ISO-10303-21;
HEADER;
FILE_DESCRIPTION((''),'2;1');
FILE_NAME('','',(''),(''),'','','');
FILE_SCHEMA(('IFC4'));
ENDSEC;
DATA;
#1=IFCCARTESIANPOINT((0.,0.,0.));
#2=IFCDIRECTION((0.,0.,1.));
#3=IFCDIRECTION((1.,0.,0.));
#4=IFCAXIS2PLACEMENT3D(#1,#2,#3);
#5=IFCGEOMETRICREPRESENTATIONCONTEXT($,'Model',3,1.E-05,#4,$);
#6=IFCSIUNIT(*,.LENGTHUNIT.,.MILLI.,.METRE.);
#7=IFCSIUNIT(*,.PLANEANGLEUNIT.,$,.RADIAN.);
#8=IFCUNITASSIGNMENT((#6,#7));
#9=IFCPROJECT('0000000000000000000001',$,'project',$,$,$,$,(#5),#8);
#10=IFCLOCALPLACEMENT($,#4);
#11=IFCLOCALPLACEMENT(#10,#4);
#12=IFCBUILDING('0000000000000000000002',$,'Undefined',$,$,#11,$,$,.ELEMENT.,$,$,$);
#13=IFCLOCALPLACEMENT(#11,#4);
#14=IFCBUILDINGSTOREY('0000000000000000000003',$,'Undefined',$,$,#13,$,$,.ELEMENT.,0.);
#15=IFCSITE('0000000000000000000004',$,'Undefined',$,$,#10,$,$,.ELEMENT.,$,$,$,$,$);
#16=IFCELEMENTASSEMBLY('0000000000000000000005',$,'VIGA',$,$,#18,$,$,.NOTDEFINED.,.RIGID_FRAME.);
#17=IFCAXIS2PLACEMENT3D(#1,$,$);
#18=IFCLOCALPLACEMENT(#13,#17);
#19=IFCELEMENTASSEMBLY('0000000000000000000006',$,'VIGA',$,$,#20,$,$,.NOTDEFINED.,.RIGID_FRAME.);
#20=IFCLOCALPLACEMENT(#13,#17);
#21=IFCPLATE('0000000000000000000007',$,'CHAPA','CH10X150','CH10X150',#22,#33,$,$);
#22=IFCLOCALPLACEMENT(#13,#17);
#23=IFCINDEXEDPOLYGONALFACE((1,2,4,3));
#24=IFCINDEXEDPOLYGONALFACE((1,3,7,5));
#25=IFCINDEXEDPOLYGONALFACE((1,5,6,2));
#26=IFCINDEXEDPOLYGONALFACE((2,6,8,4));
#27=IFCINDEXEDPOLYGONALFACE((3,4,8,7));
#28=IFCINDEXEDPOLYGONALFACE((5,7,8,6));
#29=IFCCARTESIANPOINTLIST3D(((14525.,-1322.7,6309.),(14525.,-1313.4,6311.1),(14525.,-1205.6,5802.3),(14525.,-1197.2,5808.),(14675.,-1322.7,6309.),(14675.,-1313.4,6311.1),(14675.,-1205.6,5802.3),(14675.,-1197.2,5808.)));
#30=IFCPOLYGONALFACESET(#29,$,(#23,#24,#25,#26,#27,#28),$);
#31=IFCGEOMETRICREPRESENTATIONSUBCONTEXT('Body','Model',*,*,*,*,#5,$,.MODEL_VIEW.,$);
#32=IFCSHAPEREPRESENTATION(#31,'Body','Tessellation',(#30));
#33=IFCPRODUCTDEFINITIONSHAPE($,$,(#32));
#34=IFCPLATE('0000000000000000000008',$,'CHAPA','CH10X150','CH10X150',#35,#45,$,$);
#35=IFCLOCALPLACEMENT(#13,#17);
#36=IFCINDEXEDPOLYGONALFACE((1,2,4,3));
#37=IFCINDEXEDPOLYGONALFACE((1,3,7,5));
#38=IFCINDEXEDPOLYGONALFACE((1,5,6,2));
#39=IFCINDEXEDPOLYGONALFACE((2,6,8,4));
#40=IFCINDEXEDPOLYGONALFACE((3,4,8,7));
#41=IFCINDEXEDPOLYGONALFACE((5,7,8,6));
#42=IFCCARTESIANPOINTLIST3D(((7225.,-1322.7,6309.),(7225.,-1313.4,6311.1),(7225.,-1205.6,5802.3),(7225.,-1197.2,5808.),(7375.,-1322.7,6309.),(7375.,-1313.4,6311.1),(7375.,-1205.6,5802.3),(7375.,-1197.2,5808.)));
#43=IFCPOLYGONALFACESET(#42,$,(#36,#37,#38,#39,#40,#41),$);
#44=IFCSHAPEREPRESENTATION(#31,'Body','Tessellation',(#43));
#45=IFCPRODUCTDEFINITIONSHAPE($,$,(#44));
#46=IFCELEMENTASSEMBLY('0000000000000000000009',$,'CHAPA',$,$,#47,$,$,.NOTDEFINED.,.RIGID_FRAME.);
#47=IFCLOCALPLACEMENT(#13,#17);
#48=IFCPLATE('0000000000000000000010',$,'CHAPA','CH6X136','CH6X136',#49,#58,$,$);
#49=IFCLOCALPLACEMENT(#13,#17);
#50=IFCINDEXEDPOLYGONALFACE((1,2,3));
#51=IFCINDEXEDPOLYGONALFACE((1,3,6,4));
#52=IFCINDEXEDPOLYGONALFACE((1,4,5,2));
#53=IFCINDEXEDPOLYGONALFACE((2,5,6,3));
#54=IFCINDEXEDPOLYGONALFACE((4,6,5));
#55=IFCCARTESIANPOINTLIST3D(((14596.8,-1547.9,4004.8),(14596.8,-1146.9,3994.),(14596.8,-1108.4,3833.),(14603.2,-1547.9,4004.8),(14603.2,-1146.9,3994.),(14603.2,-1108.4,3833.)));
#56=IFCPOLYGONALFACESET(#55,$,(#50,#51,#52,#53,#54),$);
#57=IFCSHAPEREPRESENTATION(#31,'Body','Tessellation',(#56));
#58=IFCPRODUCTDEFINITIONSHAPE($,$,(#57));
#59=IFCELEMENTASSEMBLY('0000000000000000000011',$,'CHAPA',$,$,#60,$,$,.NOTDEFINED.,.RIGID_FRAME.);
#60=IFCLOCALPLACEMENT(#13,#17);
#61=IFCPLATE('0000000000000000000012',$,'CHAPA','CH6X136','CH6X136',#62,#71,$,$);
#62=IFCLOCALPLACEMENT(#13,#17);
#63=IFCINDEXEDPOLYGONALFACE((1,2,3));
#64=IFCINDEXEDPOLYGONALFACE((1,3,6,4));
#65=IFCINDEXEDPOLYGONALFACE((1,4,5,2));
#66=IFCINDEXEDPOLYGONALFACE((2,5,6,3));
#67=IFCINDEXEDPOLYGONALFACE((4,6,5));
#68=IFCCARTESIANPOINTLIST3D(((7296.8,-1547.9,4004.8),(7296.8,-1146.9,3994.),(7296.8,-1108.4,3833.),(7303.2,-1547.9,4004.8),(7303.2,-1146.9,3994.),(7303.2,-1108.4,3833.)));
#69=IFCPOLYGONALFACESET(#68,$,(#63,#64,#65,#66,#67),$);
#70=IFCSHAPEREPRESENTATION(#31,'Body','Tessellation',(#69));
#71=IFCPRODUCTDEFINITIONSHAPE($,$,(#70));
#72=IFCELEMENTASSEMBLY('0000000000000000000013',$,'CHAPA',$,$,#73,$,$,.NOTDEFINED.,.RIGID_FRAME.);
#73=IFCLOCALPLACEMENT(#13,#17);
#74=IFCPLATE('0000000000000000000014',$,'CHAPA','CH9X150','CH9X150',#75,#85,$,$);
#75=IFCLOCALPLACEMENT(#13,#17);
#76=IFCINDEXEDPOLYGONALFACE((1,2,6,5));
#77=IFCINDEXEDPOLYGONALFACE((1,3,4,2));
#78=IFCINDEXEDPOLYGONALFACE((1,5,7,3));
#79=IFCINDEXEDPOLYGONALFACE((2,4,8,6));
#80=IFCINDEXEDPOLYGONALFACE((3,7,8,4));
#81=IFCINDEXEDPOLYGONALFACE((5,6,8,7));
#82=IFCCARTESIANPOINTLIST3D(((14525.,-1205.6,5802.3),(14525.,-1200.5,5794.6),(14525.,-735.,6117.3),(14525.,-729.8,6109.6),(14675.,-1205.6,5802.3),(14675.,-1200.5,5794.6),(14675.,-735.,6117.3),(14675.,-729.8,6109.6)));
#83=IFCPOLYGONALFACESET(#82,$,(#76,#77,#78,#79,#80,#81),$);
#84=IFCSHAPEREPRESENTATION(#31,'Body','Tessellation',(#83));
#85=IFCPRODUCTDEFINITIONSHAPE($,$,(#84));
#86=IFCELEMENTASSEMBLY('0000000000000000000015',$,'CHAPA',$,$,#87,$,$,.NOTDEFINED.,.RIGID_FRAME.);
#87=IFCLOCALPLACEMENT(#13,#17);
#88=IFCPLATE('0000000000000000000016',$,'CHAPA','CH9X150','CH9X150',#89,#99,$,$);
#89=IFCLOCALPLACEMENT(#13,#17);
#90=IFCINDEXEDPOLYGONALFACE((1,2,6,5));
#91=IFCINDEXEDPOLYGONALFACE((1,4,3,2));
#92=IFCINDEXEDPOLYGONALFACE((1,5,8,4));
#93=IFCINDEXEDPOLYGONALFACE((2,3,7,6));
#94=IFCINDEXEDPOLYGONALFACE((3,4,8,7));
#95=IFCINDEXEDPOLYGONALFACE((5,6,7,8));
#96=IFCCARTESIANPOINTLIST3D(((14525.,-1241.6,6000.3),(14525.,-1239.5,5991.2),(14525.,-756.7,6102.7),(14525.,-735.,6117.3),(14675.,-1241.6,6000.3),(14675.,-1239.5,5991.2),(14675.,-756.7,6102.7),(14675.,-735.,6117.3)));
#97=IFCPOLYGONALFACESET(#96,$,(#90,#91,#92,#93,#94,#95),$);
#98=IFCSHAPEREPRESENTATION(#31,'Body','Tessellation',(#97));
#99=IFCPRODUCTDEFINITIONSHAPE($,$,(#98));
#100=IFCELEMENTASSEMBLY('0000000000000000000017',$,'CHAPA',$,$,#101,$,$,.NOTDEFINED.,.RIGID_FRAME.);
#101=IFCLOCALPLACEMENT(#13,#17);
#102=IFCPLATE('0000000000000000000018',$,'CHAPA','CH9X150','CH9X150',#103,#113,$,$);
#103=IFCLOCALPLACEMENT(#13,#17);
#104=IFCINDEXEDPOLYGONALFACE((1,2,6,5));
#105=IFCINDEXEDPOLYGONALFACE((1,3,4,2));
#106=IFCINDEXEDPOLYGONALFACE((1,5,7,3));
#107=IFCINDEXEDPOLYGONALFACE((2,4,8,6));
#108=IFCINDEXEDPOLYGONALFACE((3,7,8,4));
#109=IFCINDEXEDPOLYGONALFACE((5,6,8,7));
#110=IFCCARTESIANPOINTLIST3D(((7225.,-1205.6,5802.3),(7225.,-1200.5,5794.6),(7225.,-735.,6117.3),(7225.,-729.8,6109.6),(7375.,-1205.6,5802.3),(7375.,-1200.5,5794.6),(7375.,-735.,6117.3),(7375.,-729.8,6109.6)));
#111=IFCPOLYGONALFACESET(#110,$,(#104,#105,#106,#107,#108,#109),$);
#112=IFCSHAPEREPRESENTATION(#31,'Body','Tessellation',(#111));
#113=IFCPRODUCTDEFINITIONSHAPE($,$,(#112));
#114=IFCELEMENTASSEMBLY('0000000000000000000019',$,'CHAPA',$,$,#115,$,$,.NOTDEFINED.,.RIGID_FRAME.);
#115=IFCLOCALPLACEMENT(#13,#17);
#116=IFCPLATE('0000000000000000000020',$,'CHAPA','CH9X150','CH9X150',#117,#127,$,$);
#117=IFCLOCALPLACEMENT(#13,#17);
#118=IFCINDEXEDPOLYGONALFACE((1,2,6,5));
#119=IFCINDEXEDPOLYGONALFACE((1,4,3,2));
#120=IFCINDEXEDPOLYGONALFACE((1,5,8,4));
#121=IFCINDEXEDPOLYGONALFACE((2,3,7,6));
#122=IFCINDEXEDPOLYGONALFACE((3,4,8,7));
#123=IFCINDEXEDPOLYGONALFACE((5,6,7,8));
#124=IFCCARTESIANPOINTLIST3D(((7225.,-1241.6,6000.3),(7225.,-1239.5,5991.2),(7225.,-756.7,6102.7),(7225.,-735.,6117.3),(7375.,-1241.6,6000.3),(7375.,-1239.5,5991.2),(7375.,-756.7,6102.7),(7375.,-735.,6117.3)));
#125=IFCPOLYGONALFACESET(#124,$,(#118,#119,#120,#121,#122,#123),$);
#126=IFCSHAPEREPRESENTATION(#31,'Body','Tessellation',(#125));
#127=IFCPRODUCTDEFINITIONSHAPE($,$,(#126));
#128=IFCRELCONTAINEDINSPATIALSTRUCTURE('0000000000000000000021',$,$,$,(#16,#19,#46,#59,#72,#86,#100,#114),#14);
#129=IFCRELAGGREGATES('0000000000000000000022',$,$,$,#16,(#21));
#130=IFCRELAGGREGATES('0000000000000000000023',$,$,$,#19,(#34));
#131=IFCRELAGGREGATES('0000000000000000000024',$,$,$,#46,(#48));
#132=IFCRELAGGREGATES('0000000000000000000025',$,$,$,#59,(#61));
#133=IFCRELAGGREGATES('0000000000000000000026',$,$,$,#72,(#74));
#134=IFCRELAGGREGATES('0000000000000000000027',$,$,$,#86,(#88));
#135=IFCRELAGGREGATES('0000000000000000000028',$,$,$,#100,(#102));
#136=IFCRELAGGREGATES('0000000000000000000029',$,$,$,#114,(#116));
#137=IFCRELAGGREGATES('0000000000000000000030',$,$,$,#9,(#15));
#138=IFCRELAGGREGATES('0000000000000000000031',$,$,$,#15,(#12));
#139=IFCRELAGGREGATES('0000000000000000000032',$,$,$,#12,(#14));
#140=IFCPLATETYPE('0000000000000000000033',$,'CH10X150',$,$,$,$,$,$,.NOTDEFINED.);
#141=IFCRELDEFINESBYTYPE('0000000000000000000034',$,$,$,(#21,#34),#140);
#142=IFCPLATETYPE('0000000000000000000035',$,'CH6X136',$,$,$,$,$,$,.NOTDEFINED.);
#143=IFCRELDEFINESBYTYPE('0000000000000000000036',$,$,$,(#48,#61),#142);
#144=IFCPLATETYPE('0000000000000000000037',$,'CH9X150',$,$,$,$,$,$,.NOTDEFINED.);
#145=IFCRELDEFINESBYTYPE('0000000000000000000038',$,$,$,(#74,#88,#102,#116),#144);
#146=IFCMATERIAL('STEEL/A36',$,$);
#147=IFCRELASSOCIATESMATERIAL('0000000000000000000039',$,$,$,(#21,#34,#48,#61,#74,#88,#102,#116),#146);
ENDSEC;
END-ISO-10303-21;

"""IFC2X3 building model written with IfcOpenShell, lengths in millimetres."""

from ifc_helpers import new_model, si_unit, frame, origin_with_axes, place, context, subcontext, project, spatial, polyline, outline, extrude, clip, halfspace, material, type_object, element, aggregate, save


model = new_model("IFC2X3")

# Units and contexts
model_context = context("Model", 3, precision=1e-05, world=origin_with_axes())
body_context = subcontext(model_context, "Body", "Model", "MODEL_VIEW")
ifc_project = project(units=[si_unit("LENGTHUNIT", "METRE", prefix="MILLI"), si_unit("PLANEANGLEUNIT", "RADIAN")], contexts=[model_context])

# Site, building, storey
site_placement = place(None, origin_with_axes())
site = spatial("IfcSite", under=ifc_project, at=site_placement, Name="Undefined", CompositionType="ELEMENT")
building_placement = place(site_placement, origin_with_axes())
building = spatial("IfcBuilding", under=site, at=building_placement, Name="Undefined", CompositionType="ELEMENT")
storey_placement = place(building_placement, origin_with_axes())
storey = spatial("IfcBuildingStorey", under=building, at=storey_placement, Name="Undefined", CompositionType="ELEMENT", Elevation=0.0)

# Element assemblies
assembly_1_placement = place(storey_placement, origin_with_axes())
assembly_1 = element("IfcElementAssembly", 1, at=assembly_1_placement, inside=storey, Name="VIGA", AssemblyPlace="NOTDEFINED", PredefinedType="RIGID_FRAME")
assembly_2_placement = place(storey_placement, origin_with_axes())
assembly_2 = element("IfcElementAssembly", 2, at=assembly_2_placement, inside=storey, Name="VIGA", AssemblyPlace="NOTDEFINED", PredefinedType="RIGID_FRAME")

# Plates
ifc_material_1 = material(Name="STEEL/A36")
plate_type_1 = type_object("IfcPlateType", Name="CH10X150", PredefinedType="NOTDEFINED")
plate_1_placement = place(assembly_1_placement, frame((14675.0, -1318.1, 6310.1), z_axis=(0.0, 0.97433, 0.225124), x_axis=(0.0, 0.225124, -0.97433)))
plate_1 = element("IfcPlate", 3, at=plate_1_placement, type_object=plate_type_1, material=ifc_material_1, Name="CHAPA", Description="CH10X150", ObjectType="CH10X150", context=body_context, shape_type="Clipping", body=[
    clip(extrude(outline(polyline([(0.0, 0.0), (520.0, 0.0), (520.0, 150.0), (0.0, 150.0), (0.0, 0.0)])), frame((0.0, 0.0, -4.8), z_axis=(0.0, 0.0, 1.0), x_axis=(1.0, 0.0, 0.0)), (0.0, 0.0, 1.0), 9.5), halfspace(frame((516.4, -500.0, 4.8), z_axis=(0.934951, 0.0, 0.354778), x_axis=(0.0, 1.0, 0.0)), False)),
])
aggregate(assembly_1, [plate_1])
plate_2_placement = place(assembly_2_placement, frame((7375.0, -1318.1, 6310.1), z_axis=(0.0, 0.97433, 0.225124), x_axis=(0.0, 0.225124, -0.97433)))
plate_2 = element("IfcPlate", 4, at=plate_2_placement, type_object=plate_type_1, material=ifc_material_1, Name="CHAPA", Description="CH10X150", ObjectType="CH10X150", context=body_context, shape_type="Clipping", body=[
    clip(extrude(outline(polyline([(0.0, 0.0), (520.0, 0.0), (520.0, 150.0), (0.0, 150.0), (0.0, 0.0)])), frame((0.0, 0.0, -4.8), z_axis=(0.0, 0.0, 1.0), x_axis=(1.0, 0.0, 0.0)), (0.0, 0.0, 1.0), 9.5), halfspace(frame((516.4, -500.0, 4.8), z_axis=(0.934951, 0.0, 0.354778), x_axis=(0.0, 1.0, 0.0)), False)),
])
aggregate(assembly_2, [plate_2])

# Element assemblies, plates
assembly_3_placement = place(storey_placement, origin_with_axes())
assembly_3 = element("IfcElementAssembly", 5, at=assembly_3_placement, inside=storey, Name="CHAPA", AssemblyPlace="NOTDEFINED", PredefinedType="RIGID_FRAME")
plate_type_2 = type_object("IfcPlateType", Name="CH6X136", PredefinedType="NOTDEFINED")
plate_3_placement = place(assembly_3_placement, frame((14600.0, -1146.9, 3994.0), z_axis=(1.0, 0.0, 0.0), x_axis=(0.0, -0.999636, 0.026972)))
plate_3 = element("IfcPlate", 6, at=plate_3_placement, type_object=plate_type_2, material=ifc_material_1, Name="CHAPA", Description="CH6X136", ObjectType="CH6X136", context=body_context, shape_type="SweptSolid", body=[
    extrude(outline(polyline([(0.0, 0.0), (401.1, 0.0), (-42.8, 159.9), (0.0, 0.0)])), frame((0.0, 0.0, -3.1), z_axis=(0.0, 0.0, 1.0), x_axis=(1.0, 0.0, 0.0)), (0.0, 0.0, 1.0), 6.3),
])
aggregate(assembly_3, [plate_3])
assembly_4_placement = place(storey_placement, origin_with_axes())
assembly_4 = element("IfcElementAssembly", 7, at=assembly_4_placement, inside=storey, Name="CHAPA", AssemblyPlace="NOTDEFINED", PredefinedType="RIGID_FRAME")
plate_4_placement = place(assembly_4_placement, frame((7300.0, -1146.9, 3994.0), z_axis=(1.0, 0.0, 0.0), x_axis=(0.0, -0.999636, 0.026972)))
plate_4 = element("IfcPlate", 8, at=plate_4_placement, type_object=plate_type_2, material=ifc_material_1, Name="CHAPA", Description="CH6X136", ObjectType="CH6X136", context=body_context, shape_type="SweptSolid", body=[
    extrude(outline(polyline([(0.0, 0.0), (401.1, 0.0), (-42.8, 159.9), (0.0, 0.0)])), frame((0.0, 0.0, -3.1), z_axis=(0.0, 0.0, 1.0), x_axis=(1.0, 0.0, 0.0)), (0.0, 0.0, 1.0), 6.3),
])
aggregate(assembly_4, [plate_4])
assembly_5_placement = place(storey_placement, origin_with_axes())
assembly_5 = element("IfcElementAssembly", 9, at=assembly_5_placement, inside=storey, Name="CHAPA", AssemblyPlace="NOTDEFINED", PredefinedType="RIGID_FRAME")
plate_type_3 = type_object("IfcPlateType", Name="CH9X150", PredefinedType="NOTDEFINED")
plate_5_placement = place(assembly_5_placement, frame((14675.0, -732.4, 6113.5), z_axis=(0.0, -0.55615, 0.831082), x_axis=(-1.0, 0.0, 0.0)))
plate_5 = element("IfcPlate", 10, at=plate_5_placement, type_object=plate_type_3, material=ifc_material_1, Name="CHAPA", Description="CH9X150", ObjectType="CH9X150", context=body_context, shape_type="SweptSolid", body=[
    extrude(outline(polyline([(0.0, 0.0), (150.0, 0.0), (150.0, 566.3), (0.0, 566.3), (0.0, 0.0)])), frame((0.0, 0.0, -4.7), z_axis=(0.0, 0.0, 1.0), x_axis=(1.0, 0.0, 0.0)), (0.0, 0.0, 1.0), 9.3),
])
aggregate(assembly_5, [plate_5])
assembly_6_placement = place(storey_placement, origin_with_axes())
assembly_6 = element("IfcElementAssembly", 11, at=assembly_6_placement, inside=storey, Name="CHAPA", AssemblyPlace="NOTDEFINED", PredefinedType="RIGID_FRAME")
plate_6_placement = place(assembly_6_placement, frame((14675.0, -1240.6, 5995.7), z_axis=(0.0, -0.225124, 0.97433), x_axis=(0.0, 0.97433, 0.225124)))
plate_6 = element("IfcPlate", 12, at=plate_6_placement, type_object=plate_type_3, material=ifc_material_1, Name="CHAPA", Description="CH9X150", ObjectType="CH9X150", context=body_context, shape_type="Clipping", body=[
    clip(extrude(outline(polyline([(0.0, 0.0), (520.0, 0.0), (520.0, 150.0), (0.0, 150.0), (0.0, 0.0)])), frame((0.0, 0.0, -4.7), z_axis=(0.0, 0.0, 1.0), x_axis=(1.0, 0.0, 0.0)), (0.0, 0.0, 1.0), 9.3), halfspace(frame((520.0, -500.0, 4.7), z_axis=(0.354778, 0.0, -0.934951), x_axis=(0.0, 1.0, 0.0)), False)),
])
aggregate(assembly_6, [plate_6])
assembly_7_placement = place(storey_placement, origin_with_axes())
assembly_7 = element("IfcElementAssembly", 13, at=assembly_7_placement, inside=storey, Name="CHAPA", AssemblyPlace="NOTDEFINED", PredefinedType="RIGID_FRAME")
plate_7_placement = place(assembly_7_placement, frame((7375.0, -732.4, 6113.5), z_axis=(0.0, -0.55615, 0.831082), x_axis=(-1.0, 0.0, 0.0)))
plate_7 = element("IfcPlate", 14, at=plate_7_placement, type_object=plate_type_3, material=ifc_material_1, Name="CHAPA", Description="CH9X150", ObjectType="CH9X150", context=body_context, shape_type="SweptSolid", body=[
    extrude(outline(polyline([(0.0, 0.0), (150.0, 0.0), (150.0, 566.3), (0.0, 566.3), (0.0, 0.0)])), frame((0.0, 0.0, -4.7), z_axis=(0.0, 0.0, 1.0), x_axis=(1.0, 0.0, 0.0)), (0.0, 0.0, 1.0), 9.3),
])
aggregate(assembly_7, [plate_7])
assembly_8_placement = place(storey_placement, origin_with_axes())
assembly_8 = element("IfcElementAssembly", 15, at=assembly_8_placement, inside=storey, Name="CHAPA", AssemblyPlace="NOTDEFINED", PredefinedType="RIGID_FRAME")
plate_8_placement = place(assembly_8_placement, frame((7375.0, -1240.6, 5995.7), z_axis=(0.0, -0.225124, 0.97433), x_axis=(0.0, 0.97433, 0.225124)))
plate_8 = element("IfcPlate", 16, at=plate_8_placement, type_object=plate_type_3, material=ifc_material_1, Name="CHAPA", Description="CH9X150", ObjectType="CH9X150", context=body_context, shape_type="Clipping", body=[
    clip(extrude(outline(polyline([(0.0, 0.0), (520.0, 0.0), (520.0, 150.0), (0.0, 150.0), (0.0, 0.0)])), frame((0.0, 0.0, -4.7), z_axis=(0.0, 0.0, 1.0), x_axis=(1.0, 0.0, 0.0)), (0.0, 0.0, 1.0), 9.3), halfspace(frame((520.0, -500.0, 4.7), z_axis=(0.354778, 0.0, -0.934951), x_axis=(0.0, 1.0, 0.0)), False)),
])
aggregate(assembly_8, [plate_8])

save(model, "model.ifc")
